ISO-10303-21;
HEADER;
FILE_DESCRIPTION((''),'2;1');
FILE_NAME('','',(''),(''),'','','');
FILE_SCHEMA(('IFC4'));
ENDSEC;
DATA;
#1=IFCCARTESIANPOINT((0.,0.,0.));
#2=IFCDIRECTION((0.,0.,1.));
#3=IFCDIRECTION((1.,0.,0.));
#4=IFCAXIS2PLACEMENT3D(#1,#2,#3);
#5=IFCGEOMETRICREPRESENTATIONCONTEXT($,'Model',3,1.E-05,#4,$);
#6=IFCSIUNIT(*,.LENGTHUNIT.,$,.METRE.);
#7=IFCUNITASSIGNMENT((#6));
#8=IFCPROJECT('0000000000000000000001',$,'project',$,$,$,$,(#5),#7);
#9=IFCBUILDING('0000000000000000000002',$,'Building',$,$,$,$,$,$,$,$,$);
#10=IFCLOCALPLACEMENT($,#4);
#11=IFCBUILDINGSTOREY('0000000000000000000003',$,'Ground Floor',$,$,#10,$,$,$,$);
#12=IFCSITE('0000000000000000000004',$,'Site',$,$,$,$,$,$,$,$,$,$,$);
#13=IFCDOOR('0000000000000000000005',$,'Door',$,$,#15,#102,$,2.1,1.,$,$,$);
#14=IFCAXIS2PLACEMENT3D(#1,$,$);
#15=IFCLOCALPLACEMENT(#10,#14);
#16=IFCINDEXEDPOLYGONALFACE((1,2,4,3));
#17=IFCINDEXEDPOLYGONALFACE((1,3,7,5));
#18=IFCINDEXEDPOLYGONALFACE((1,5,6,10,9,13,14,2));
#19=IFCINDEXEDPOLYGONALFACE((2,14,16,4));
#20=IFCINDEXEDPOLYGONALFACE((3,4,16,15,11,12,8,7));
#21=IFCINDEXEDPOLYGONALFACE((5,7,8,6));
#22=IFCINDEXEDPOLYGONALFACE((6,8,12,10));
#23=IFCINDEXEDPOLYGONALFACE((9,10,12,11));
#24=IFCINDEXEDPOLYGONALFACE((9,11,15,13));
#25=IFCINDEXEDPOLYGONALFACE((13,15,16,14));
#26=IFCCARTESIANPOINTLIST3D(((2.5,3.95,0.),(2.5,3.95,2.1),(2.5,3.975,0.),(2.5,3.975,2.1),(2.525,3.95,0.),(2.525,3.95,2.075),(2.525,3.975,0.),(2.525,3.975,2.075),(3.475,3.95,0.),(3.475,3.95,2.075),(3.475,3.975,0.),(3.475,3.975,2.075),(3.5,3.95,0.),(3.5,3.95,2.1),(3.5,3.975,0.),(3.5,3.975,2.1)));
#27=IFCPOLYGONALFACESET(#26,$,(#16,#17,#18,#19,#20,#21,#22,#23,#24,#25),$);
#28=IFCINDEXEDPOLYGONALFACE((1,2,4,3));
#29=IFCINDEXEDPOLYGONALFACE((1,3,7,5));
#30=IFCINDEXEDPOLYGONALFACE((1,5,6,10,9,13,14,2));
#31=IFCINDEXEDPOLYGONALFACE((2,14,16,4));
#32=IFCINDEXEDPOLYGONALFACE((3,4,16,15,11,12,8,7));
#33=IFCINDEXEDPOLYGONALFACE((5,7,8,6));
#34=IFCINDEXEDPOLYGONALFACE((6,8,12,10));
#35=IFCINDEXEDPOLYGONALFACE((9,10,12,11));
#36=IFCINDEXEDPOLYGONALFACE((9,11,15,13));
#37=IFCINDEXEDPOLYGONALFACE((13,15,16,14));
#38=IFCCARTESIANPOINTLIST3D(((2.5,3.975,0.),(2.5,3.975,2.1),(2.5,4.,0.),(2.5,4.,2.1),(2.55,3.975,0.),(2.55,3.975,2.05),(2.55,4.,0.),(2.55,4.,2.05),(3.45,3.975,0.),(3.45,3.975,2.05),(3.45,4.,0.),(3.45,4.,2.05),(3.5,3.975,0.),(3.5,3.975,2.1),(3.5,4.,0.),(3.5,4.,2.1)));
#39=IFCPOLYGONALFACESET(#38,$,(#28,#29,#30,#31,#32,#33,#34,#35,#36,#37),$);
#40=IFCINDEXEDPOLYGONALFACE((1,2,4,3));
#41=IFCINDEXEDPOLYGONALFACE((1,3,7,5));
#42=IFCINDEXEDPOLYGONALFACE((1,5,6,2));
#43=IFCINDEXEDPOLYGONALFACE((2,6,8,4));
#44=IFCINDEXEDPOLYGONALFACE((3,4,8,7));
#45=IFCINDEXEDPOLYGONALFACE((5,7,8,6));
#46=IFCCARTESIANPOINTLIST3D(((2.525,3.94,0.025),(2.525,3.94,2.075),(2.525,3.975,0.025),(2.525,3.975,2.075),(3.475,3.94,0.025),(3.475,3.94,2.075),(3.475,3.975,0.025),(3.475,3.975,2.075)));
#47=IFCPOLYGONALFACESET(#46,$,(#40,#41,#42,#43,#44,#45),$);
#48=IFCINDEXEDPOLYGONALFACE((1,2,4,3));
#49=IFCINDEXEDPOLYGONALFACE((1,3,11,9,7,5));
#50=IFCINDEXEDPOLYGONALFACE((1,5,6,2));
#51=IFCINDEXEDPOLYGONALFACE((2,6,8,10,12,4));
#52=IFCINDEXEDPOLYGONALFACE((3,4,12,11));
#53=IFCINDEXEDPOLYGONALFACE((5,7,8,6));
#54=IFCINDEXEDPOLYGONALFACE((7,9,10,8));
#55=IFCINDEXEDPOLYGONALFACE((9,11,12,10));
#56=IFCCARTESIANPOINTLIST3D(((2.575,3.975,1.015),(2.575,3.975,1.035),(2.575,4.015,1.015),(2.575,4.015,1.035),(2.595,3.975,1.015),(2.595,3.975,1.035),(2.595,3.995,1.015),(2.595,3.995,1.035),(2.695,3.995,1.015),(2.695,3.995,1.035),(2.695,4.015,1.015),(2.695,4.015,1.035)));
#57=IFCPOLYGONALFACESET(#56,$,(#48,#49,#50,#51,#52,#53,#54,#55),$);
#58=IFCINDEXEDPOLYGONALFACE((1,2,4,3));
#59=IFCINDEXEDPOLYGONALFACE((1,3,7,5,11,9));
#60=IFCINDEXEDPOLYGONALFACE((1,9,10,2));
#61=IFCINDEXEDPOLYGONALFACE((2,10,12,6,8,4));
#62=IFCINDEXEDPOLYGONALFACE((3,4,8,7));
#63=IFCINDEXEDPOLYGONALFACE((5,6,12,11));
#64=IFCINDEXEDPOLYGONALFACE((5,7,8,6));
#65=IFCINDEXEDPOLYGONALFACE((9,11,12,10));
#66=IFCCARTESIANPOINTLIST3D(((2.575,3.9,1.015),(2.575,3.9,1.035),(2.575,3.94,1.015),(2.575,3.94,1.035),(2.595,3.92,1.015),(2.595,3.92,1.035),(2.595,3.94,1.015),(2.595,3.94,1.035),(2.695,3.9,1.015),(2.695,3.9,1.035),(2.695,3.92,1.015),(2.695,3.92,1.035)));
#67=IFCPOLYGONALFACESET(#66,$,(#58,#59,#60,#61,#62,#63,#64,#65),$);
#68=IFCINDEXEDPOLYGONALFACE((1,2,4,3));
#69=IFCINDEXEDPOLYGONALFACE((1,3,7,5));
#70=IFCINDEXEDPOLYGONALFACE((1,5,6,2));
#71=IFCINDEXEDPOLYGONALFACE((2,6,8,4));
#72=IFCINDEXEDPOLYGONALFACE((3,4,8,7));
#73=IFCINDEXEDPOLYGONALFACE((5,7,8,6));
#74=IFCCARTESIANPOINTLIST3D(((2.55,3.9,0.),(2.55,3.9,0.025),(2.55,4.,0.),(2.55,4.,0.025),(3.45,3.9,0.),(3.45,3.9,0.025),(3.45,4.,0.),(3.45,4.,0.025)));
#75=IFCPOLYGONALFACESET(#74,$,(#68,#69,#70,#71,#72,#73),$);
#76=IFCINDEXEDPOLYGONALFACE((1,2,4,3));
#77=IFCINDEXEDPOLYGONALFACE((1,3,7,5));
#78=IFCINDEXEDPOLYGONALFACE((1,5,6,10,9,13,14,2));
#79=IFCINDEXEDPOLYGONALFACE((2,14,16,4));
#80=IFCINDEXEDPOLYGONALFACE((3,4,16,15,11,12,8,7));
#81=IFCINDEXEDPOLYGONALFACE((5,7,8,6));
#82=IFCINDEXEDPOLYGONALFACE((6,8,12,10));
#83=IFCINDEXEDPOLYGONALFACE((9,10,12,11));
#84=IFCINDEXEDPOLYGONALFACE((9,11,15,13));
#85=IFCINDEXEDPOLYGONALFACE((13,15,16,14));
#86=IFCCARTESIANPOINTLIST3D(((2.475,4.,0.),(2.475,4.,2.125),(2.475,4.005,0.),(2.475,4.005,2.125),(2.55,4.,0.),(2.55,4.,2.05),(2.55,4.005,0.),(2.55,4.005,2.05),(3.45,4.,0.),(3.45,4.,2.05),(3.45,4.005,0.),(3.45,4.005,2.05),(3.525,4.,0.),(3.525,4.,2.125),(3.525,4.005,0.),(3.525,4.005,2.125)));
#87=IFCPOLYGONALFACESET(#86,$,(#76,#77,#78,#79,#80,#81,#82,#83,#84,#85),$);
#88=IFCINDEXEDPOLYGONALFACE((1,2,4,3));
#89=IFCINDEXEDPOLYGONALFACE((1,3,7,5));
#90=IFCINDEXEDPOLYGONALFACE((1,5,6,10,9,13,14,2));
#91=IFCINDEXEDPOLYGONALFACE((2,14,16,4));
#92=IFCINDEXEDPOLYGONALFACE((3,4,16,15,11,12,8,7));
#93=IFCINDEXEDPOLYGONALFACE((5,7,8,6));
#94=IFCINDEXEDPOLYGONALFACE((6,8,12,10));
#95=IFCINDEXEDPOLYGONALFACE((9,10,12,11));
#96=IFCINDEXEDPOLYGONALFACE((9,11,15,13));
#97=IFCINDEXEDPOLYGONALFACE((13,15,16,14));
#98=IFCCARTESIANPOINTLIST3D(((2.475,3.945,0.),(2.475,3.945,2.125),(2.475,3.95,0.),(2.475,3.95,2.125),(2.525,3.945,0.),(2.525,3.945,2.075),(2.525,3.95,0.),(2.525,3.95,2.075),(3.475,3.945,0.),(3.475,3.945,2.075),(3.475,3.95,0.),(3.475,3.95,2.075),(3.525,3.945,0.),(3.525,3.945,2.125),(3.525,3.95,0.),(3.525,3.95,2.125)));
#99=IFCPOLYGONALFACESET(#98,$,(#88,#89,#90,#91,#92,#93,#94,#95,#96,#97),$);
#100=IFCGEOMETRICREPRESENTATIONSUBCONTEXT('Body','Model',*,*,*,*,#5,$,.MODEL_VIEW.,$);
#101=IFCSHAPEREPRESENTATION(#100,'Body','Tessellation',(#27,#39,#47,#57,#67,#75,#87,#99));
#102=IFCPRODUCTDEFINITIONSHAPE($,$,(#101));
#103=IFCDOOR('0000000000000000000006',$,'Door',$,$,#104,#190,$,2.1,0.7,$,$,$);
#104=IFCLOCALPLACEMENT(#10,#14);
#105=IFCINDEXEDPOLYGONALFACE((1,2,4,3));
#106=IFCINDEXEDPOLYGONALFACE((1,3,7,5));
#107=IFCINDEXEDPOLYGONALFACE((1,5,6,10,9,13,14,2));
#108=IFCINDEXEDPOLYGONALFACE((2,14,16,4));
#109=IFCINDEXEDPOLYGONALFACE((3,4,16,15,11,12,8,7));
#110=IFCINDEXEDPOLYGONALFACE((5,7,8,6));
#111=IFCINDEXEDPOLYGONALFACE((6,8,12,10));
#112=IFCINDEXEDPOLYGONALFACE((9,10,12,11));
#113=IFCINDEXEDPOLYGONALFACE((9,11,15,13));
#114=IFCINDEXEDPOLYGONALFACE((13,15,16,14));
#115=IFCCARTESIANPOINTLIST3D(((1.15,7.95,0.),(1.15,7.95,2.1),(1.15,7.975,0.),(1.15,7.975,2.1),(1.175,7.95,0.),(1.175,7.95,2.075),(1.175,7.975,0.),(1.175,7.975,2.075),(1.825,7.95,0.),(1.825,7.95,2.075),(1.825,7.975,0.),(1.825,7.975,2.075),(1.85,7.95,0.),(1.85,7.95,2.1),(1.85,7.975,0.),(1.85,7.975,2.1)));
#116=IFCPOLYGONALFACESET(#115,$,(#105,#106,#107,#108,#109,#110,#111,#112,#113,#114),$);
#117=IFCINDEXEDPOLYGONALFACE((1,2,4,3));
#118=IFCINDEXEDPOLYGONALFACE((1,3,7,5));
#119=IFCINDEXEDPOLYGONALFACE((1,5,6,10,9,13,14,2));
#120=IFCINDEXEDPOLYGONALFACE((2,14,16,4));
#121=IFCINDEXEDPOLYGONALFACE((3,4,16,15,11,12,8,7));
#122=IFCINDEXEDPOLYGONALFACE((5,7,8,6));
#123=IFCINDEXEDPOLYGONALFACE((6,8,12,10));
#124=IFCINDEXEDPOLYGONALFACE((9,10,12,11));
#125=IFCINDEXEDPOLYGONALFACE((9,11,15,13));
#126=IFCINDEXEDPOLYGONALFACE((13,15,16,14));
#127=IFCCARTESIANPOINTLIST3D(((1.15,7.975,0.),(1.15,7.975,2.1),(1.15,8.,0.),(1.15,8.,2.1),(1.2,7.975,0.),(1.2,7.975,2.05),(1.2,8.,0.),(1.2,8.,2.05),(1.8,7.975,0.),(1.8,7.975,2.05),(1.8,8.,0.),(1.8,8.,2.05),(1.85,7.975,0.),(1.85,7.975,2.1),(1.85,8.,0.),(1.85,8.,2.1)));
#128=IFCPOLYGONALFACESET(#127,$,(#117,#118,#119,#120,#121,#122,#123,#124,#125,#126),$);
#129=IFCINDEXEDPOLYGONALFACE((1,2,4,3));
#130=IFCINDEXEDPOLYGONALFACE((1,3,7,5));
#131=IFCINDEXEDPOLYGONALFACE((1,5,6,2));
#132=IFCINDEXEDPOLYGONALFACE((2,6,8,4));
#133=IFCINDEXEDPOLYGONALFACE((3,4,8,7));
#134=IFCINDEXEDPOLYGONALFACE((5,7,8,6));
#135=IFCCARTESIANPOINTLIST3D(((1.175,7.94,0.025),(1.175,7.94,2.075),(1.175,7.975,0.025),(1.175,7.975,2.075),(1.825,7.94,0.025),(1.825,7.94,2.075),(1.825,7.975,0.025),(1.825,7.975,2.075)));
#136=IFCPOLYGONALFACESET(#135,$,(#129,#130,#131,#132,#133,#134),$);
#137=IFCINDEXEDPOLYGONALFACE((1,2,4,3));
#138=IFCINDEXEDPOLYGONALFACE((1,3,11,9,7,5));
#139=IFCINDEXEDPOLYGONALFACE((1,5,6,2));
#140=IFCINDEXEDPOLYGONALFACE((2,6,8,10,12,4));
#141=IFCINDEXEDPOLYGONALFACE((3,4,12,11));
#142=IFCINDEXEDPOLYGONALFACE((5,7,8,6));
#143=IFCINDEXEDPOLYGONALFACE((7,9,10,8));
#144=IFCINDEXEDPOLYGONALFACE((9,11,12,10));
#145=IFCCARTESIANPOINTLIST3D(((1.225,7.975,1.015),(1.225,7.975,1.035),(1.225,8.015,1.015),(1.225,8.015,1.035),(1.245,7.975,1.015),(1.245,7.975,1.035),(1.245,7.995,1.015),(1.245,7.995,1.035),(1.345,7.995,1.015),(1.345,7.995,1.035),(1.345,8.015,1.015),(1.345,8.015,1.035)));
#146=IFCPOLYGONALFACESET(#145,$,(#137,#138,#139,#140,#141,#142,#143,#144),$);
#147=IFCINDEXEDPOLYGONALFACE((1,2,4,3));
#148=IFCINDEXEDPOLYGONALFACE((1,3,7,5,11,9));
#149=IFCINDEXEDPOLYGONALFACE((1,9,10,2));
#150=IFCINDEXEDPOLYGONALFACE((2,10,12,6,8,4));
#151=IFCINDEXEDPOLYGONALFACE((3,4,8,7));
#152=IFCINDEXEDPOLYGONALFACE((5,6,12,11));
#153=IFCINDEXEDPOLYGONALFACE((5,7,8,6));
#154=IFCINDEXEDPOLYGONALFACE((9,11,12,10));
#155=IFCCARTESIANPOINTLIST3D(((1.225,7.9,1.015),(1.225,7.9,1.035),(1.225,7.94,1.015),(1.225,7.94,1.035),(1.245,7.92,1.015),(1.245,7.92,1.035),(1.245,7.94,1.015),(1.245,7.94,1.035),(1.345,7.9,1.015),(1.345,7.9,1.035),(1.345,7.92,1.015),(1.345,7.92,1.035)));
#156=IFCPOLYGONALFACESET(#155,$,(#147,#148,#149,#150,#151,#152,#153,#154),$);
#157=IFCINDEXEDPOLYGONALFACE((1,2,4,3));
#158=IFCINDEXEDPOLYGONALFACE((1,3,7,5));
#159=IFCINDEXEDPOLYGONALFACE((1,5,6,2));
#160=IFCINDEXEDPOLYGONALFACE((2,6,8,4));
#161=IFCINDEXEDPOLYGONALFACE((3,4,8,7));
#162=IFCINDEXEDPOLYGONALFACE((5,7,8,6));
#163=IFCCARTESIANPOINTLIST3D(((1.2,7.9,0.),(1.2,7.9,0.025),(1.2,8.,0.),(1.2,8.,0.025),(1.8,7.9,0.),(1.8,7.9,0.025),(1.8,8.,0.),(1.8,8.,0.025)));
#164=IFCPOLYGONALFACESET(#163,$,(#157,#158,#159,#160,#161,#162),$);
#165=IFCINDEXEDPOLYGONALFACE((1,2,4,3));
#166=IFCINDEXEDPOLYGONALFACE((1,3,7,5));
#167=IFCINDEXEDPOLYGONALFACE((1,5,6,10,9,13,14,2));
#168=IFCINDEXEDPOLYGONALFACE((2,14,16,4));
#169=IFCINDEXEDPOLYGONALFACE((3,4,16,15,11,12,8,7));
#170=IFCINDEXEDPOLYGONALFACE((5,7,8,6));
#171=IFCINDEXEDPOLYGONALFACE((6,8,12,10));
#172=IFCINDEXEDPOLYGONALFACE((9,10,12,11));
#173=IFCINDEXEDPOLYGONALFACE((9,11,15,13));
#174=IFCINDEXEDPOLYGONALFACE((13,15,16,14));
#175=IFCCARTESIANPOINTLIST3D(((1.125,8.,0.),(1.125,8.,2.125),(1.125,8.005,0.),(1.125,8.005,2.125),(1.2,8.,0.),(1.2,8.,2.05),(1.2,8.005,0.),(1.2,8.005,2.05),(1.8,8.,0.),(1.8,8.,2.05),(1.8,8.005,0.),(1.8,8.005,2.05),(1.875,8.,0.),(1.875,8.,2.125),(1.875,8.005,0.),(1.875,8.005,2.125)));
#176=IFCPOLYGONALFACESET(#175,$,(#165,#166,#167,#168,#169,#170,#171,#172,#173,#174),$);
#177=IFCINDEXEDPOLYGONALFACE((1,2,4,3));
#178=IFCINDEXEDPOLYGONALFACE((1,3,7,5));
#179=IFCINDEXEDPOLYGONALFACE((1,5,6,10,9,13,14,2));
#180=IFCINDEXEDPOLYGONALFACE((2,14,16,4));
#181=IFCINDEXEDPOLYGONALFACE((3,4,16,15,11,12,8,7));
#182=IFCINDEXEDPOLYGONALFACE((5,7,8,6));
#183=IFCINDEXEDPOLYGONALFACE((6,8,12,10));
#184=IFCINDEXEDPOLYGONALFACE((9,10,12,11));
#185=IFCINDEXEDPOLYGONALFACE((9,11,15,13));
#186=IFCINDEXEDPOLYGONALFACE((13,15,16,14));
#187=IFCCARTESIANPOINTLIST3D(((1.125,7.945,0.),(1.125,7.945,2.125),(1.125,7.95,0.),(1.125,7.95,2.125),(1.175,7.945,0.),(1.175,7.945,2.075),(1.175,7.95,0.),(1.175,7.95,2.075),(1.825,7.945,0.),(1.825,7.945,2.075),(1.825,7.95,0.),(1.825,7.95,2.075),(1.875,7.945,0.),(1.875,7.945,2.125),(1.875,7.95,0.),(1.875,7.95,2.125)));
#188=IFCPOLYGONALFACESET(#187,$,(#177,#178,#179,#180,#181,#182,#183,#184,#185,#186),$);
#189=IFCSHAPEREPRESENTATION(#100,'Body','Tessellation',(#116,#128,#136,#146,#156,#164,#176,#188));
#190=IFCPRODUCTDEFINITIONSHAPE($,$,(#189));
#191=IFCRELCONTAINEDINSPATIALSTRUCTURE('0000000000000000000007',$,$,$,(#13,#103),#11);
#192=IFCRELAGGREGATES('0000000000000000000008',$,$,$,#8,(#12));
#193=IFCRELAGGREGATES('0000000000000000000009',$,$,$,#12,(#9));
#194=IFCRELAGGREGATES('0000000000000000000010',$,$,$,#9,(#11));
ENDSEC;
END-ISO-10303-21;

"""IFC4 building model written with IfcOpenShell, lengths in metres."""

from ifc_helpers import new_model, si_unit, frame, origin_with_axes, place, context, subcontext, project, spatial, line, indexed_curve, outline, extrude, element, save


model = new_model("IFC4")

# Units and contexts
model_context = context("Model", 3, precision=1e-05, world=origin_with_axes())
body_context = subcontext(model_context, "Body", "Model", "MODEL_VIEW")
ifc_project = project(units=[si_unit("LENGTHUNIT", "METRE")], contexts=[model_context])

# Site, building, storey
site = spatial("IfcSite", under=ifc_project, Name="Site")
building = spatial("IfcBuilding", under=site, Name="Building")
storey_placement = place(None, origin_with_axes())
storey = spatial("IfcBuildingStorey", under=building, at=storey_placement, Name="Ground Floor")

# Doors
door_1_placement = place(storey_placement, frame((3.5, 4.0, 0.0), z_axis=(0.0, 0.0, 1.0), x_axis=(-1.0, 0.0, 0.0)))
element("IfcDoor", 1, at=door_1_placement, inside=storey, Name="Door", OverallHeight=2.1, OverallWidth=1.0, context=body_context, shape_type="SweptSolid", body=[
    extrude(outline(indexed_curve([(0.0, 0.0), (0.0, 2.1), (1.0, 2.1), (1.0, 0.0), (0.975, 0.0), (0.975, 2.075), (0.025, 2.075), (0.025, 0.0)], segments=[line(1, 2, 3, 4, 5, 6, 7, 8, 1)])), frame((0.0, 0.025, 0.0), z_axis=(0.0, -1.0, 0.0), x_axis=(1.0, 0.0, 0.0)), (0.0, 0.0, -1.0), 0.025),
    extrude(outline(indexed_curve([(0.0, 0.0), (0.0, 2.1), (1.0, 2.1), (1.0, 0.0), (0.95, 0.0), (0.95, 2.05), (0.05, 2.05), (0.05, 0.0)], segments=[line(1, 2, 3, 4, 5, 6, 7, 8, 1)])), frame((0.0, 0.0, 0.0), z_axis=(0.0, -1.0, 0.0), x_axis=(1.0, 0.0, 0.0)), (0.0, 0.0, -1.0), 0.025),
    extrude(outline(indexed_curve([(0.0, 0.0), (0.95, 0.0), (0.95, 0.035), (0.0, 0.035)], segments=[line(1, 2, 3, 4, 1)])), frame((0.025, 0.025, 0.025), z_axis=(0.0, 0.0, 1.0), x_axis=(1.0, 0.0, 0.0)), (0.0, 0.0, 1.0), 2.05),
    extrude(outline(indexed_curve([(0.0, 0.0), (0.0, -0.04), (-0.12, -0.04), (-0.12, -0.02), (-0.02, -0.02), (-0.02, 0.0)], segments=[line(1, 2, 3, 4, 5, 6, 1)])), frame((0.925, 0.025, 1.015), z_axis=(0.0, 0.0, 1.0), x_axis=(1.0, 0.0, 0.0)), (0.0, 0.0, 1.0), 0.02),
    extrude(outline(indexed_curve([(0.0, 0.0), (0.0, 0.04), (-0.12, 0.04), (-0.12, 0.02), (-0.02, 0.02), (-0.02, 0.0)], segments=[line(1, 2, 3, 4, 5, 6, 1)])), frame((0.925, 0.06, 1.015), z_axis=(0.0, 0.0, 1.0), x_axis=(1.0, 0.0, 0.0)), (0.0, 0.0, 1.0), 0.02),
    extrude(outline(indexed_curve([(0.0, 0.0), (0.9, 0.0), (0.9, 0.1), (0.0, 0.1)], segments=[line(1, 2, 3, 4, 1)])), frame((0.05, 0.0, 0.0), z_axis=(0.0, 0.0, 1.0), x_axis=(1.0, 0.0, 0.0)), (0.0, 0.0, 1.0), 0.025),
    extrude(outline(indexed_curve([(0.0, 0.0), (0.0, 2.125), (1.05, 2.125), (1.05, 0.0), (0.975, 0.0), (0.975, 2.05), (0.075, 2.05), (0.075, 0.0)], segments=[line(1, 2, 3, 4, 5, 6, 7, 8, 1)])), frame((-0.025, -0.005, 0.0), z_axis=(0.0, -1.0, 0.0), x_axis=(1.0, 0.0, 0.0)), (0.0, 0.0, -1.0), 0.005),
    extrude(outline(indexed_curve([(0.0, 0.0), (0.0, 2.125), (1.05, 2.125), (1.05, 0.0), (1.0, 0.0), (1.0, 2.075), (0.05, 2.075), (0.05, 0.0)], segments=[line(1, 2, 3, 4, 5, 6, 7, 8, 1)])), frame((-0.025, 0.05, 0.0), z_axis=(0.0, -1.0, 0.0), x_axis=(1.0, 0.0, 0.0)), (0.0, 0.0, -1.0), 0.005),
])
door_2_placement = place(storey_placement, frame((1.85, 8.0, 0.0), z_axis=(0.0, 0.0, 1.0), x_axis=(-1.0, 0.0, 0.0)))
element("IfcDoor", 2, at=door_2_placement, inside=storey, Name="Door", OverallHeight=2.1, OverallWidth=0.7, context=body_context, shape_type="SweptSolid", body=[
    extrude(outline(indexed_curve([(0.0, 0.0), (0.0, 2.1), (0.7, 2.1), (0.7, 0.0), (0.675, 0.0), (0.675, 2.075), (0.025, 2.075), (0.025, 0.0)], segments=[line(1, 2, 3, 4, 5, 6, 7, 8, 1)])), frame((0.0, 0.025, 0.0), z_axis=(0.0, -1.0, 0.0), x_axis=(1.0, 0.0, 0.0)), (0.0, 0.0, -1.0), 0.025),
    extrude(outline(indexed_curve([(0.0, 0.0), (0.0, 2.1), (0.7, 2.1), (0.7, 0.0), (0.65, 0.0), (0.65, 2.05), (0.05, 2.05), (0.05, 0.0)], segments=[line(1, 2, 3, 4, 5, 6, 7, 8, 1)])), frame((0.0, 0.0, 0.0), z_axis=(0.0, -1.0, 0.0), x_axis=(1.0, 0.0, 0.0)), (0.0, 0.0, -1.0), 0.025),
    extrude(outline(indexed_curve([(0.0, 0.0), (0.65, 0.0), (0.65, 0.035), (0.0, 0.035)], segments=[line(1, 2, 3, 4, 1)])), frame((0.025, 0.025, 0.025), z_axis=(0.0, 0.0, 1.0), x_axis=(1.0, 0.0, 0.0)), (0.0, 0.0, 1.0), 2.05),
    extrude(outline(indexed_curve([(0.0, 0.0), (0.0, -0.04), (-0.12, -0.04), (-0.12, -0.02), (-0.02, -0.02), (-0.02, 0.0)], segments=[line(1, 2, 3, 4, 5, 6, 1)])), frame((0.625, 0.025, 1.015), z_axis=(0.0, 0.0, 1.0), x_axis=(1.0, 0.0, 0.0)), (0.0, 0.0, 1.0), 0.02),
    extrude(outline(indexed_curve([(0.0, 0.0), (0.0, 0.04), (-0.12, 0.04), (-0.12, 0.02), (-0.02, 0.02), (-0.02, 0.0)], segments=[line(1, 2, 3, 4, 5, 6, 1)])), frame((0.625, 0.06, 1.015), z_axis=(0.0, 0.0, 1.0), x_axis=(1.0, 0.0, 0.0)), (0.0, 0.0, 1.0), 0.02),
    extrude(outline(indexed_curve([(0.0, 0.0), (0.6, 0.0), (0.6, 0.1), (0.0, 0.1)], segments=[line(1, 2, 3, 4, 1)])), frame((0.05, 0.0, 0.0), z_axis=(0.0, 0.0, 1.0), x_axis=(1.0, 0.0, 0.0)), (0.0, 0.0, 1.0), 0.025),
    extrude(outline(indexed_curve([(0.0, 0.0), (0.0, 2.125), (0.75, 2.125), (0.75, 0.0), (0.675, 0.0), (0.675, 2.05), (0.075, 2.05), (0.075, 0.0)], segments=[line(1, 2, 3, 4, 5, 6, 7, 8, 1)])), frame((-0.025, -0.005, 0.0), z_axis=(0.0, -1.0, 0.0), x_axis=(1.0, 0.0, 0.0)), (0.0, 0.0, -1.0), 0.005),
    extrude(outline(indexed_curve([(0.0, 0.0), (0.0, 2.125), (0.75, 2.125), (0.75, 0.0), (0.7, 0.0), (0.7, 2.075), (0.05, 2.075), (0.05, 0.0)], segments=[line(1, 2, 3, 4, 5, 6, 7, 8, 1)])), frame((-0.025, 0.05, 0.0), z_axis=(0.0, -1.0, 0.0), x_axis=(1.0, 0.0, 0.0)), (0.0, 0.0, -1.0), 0.005),
])

save(model, "model.ifc")
